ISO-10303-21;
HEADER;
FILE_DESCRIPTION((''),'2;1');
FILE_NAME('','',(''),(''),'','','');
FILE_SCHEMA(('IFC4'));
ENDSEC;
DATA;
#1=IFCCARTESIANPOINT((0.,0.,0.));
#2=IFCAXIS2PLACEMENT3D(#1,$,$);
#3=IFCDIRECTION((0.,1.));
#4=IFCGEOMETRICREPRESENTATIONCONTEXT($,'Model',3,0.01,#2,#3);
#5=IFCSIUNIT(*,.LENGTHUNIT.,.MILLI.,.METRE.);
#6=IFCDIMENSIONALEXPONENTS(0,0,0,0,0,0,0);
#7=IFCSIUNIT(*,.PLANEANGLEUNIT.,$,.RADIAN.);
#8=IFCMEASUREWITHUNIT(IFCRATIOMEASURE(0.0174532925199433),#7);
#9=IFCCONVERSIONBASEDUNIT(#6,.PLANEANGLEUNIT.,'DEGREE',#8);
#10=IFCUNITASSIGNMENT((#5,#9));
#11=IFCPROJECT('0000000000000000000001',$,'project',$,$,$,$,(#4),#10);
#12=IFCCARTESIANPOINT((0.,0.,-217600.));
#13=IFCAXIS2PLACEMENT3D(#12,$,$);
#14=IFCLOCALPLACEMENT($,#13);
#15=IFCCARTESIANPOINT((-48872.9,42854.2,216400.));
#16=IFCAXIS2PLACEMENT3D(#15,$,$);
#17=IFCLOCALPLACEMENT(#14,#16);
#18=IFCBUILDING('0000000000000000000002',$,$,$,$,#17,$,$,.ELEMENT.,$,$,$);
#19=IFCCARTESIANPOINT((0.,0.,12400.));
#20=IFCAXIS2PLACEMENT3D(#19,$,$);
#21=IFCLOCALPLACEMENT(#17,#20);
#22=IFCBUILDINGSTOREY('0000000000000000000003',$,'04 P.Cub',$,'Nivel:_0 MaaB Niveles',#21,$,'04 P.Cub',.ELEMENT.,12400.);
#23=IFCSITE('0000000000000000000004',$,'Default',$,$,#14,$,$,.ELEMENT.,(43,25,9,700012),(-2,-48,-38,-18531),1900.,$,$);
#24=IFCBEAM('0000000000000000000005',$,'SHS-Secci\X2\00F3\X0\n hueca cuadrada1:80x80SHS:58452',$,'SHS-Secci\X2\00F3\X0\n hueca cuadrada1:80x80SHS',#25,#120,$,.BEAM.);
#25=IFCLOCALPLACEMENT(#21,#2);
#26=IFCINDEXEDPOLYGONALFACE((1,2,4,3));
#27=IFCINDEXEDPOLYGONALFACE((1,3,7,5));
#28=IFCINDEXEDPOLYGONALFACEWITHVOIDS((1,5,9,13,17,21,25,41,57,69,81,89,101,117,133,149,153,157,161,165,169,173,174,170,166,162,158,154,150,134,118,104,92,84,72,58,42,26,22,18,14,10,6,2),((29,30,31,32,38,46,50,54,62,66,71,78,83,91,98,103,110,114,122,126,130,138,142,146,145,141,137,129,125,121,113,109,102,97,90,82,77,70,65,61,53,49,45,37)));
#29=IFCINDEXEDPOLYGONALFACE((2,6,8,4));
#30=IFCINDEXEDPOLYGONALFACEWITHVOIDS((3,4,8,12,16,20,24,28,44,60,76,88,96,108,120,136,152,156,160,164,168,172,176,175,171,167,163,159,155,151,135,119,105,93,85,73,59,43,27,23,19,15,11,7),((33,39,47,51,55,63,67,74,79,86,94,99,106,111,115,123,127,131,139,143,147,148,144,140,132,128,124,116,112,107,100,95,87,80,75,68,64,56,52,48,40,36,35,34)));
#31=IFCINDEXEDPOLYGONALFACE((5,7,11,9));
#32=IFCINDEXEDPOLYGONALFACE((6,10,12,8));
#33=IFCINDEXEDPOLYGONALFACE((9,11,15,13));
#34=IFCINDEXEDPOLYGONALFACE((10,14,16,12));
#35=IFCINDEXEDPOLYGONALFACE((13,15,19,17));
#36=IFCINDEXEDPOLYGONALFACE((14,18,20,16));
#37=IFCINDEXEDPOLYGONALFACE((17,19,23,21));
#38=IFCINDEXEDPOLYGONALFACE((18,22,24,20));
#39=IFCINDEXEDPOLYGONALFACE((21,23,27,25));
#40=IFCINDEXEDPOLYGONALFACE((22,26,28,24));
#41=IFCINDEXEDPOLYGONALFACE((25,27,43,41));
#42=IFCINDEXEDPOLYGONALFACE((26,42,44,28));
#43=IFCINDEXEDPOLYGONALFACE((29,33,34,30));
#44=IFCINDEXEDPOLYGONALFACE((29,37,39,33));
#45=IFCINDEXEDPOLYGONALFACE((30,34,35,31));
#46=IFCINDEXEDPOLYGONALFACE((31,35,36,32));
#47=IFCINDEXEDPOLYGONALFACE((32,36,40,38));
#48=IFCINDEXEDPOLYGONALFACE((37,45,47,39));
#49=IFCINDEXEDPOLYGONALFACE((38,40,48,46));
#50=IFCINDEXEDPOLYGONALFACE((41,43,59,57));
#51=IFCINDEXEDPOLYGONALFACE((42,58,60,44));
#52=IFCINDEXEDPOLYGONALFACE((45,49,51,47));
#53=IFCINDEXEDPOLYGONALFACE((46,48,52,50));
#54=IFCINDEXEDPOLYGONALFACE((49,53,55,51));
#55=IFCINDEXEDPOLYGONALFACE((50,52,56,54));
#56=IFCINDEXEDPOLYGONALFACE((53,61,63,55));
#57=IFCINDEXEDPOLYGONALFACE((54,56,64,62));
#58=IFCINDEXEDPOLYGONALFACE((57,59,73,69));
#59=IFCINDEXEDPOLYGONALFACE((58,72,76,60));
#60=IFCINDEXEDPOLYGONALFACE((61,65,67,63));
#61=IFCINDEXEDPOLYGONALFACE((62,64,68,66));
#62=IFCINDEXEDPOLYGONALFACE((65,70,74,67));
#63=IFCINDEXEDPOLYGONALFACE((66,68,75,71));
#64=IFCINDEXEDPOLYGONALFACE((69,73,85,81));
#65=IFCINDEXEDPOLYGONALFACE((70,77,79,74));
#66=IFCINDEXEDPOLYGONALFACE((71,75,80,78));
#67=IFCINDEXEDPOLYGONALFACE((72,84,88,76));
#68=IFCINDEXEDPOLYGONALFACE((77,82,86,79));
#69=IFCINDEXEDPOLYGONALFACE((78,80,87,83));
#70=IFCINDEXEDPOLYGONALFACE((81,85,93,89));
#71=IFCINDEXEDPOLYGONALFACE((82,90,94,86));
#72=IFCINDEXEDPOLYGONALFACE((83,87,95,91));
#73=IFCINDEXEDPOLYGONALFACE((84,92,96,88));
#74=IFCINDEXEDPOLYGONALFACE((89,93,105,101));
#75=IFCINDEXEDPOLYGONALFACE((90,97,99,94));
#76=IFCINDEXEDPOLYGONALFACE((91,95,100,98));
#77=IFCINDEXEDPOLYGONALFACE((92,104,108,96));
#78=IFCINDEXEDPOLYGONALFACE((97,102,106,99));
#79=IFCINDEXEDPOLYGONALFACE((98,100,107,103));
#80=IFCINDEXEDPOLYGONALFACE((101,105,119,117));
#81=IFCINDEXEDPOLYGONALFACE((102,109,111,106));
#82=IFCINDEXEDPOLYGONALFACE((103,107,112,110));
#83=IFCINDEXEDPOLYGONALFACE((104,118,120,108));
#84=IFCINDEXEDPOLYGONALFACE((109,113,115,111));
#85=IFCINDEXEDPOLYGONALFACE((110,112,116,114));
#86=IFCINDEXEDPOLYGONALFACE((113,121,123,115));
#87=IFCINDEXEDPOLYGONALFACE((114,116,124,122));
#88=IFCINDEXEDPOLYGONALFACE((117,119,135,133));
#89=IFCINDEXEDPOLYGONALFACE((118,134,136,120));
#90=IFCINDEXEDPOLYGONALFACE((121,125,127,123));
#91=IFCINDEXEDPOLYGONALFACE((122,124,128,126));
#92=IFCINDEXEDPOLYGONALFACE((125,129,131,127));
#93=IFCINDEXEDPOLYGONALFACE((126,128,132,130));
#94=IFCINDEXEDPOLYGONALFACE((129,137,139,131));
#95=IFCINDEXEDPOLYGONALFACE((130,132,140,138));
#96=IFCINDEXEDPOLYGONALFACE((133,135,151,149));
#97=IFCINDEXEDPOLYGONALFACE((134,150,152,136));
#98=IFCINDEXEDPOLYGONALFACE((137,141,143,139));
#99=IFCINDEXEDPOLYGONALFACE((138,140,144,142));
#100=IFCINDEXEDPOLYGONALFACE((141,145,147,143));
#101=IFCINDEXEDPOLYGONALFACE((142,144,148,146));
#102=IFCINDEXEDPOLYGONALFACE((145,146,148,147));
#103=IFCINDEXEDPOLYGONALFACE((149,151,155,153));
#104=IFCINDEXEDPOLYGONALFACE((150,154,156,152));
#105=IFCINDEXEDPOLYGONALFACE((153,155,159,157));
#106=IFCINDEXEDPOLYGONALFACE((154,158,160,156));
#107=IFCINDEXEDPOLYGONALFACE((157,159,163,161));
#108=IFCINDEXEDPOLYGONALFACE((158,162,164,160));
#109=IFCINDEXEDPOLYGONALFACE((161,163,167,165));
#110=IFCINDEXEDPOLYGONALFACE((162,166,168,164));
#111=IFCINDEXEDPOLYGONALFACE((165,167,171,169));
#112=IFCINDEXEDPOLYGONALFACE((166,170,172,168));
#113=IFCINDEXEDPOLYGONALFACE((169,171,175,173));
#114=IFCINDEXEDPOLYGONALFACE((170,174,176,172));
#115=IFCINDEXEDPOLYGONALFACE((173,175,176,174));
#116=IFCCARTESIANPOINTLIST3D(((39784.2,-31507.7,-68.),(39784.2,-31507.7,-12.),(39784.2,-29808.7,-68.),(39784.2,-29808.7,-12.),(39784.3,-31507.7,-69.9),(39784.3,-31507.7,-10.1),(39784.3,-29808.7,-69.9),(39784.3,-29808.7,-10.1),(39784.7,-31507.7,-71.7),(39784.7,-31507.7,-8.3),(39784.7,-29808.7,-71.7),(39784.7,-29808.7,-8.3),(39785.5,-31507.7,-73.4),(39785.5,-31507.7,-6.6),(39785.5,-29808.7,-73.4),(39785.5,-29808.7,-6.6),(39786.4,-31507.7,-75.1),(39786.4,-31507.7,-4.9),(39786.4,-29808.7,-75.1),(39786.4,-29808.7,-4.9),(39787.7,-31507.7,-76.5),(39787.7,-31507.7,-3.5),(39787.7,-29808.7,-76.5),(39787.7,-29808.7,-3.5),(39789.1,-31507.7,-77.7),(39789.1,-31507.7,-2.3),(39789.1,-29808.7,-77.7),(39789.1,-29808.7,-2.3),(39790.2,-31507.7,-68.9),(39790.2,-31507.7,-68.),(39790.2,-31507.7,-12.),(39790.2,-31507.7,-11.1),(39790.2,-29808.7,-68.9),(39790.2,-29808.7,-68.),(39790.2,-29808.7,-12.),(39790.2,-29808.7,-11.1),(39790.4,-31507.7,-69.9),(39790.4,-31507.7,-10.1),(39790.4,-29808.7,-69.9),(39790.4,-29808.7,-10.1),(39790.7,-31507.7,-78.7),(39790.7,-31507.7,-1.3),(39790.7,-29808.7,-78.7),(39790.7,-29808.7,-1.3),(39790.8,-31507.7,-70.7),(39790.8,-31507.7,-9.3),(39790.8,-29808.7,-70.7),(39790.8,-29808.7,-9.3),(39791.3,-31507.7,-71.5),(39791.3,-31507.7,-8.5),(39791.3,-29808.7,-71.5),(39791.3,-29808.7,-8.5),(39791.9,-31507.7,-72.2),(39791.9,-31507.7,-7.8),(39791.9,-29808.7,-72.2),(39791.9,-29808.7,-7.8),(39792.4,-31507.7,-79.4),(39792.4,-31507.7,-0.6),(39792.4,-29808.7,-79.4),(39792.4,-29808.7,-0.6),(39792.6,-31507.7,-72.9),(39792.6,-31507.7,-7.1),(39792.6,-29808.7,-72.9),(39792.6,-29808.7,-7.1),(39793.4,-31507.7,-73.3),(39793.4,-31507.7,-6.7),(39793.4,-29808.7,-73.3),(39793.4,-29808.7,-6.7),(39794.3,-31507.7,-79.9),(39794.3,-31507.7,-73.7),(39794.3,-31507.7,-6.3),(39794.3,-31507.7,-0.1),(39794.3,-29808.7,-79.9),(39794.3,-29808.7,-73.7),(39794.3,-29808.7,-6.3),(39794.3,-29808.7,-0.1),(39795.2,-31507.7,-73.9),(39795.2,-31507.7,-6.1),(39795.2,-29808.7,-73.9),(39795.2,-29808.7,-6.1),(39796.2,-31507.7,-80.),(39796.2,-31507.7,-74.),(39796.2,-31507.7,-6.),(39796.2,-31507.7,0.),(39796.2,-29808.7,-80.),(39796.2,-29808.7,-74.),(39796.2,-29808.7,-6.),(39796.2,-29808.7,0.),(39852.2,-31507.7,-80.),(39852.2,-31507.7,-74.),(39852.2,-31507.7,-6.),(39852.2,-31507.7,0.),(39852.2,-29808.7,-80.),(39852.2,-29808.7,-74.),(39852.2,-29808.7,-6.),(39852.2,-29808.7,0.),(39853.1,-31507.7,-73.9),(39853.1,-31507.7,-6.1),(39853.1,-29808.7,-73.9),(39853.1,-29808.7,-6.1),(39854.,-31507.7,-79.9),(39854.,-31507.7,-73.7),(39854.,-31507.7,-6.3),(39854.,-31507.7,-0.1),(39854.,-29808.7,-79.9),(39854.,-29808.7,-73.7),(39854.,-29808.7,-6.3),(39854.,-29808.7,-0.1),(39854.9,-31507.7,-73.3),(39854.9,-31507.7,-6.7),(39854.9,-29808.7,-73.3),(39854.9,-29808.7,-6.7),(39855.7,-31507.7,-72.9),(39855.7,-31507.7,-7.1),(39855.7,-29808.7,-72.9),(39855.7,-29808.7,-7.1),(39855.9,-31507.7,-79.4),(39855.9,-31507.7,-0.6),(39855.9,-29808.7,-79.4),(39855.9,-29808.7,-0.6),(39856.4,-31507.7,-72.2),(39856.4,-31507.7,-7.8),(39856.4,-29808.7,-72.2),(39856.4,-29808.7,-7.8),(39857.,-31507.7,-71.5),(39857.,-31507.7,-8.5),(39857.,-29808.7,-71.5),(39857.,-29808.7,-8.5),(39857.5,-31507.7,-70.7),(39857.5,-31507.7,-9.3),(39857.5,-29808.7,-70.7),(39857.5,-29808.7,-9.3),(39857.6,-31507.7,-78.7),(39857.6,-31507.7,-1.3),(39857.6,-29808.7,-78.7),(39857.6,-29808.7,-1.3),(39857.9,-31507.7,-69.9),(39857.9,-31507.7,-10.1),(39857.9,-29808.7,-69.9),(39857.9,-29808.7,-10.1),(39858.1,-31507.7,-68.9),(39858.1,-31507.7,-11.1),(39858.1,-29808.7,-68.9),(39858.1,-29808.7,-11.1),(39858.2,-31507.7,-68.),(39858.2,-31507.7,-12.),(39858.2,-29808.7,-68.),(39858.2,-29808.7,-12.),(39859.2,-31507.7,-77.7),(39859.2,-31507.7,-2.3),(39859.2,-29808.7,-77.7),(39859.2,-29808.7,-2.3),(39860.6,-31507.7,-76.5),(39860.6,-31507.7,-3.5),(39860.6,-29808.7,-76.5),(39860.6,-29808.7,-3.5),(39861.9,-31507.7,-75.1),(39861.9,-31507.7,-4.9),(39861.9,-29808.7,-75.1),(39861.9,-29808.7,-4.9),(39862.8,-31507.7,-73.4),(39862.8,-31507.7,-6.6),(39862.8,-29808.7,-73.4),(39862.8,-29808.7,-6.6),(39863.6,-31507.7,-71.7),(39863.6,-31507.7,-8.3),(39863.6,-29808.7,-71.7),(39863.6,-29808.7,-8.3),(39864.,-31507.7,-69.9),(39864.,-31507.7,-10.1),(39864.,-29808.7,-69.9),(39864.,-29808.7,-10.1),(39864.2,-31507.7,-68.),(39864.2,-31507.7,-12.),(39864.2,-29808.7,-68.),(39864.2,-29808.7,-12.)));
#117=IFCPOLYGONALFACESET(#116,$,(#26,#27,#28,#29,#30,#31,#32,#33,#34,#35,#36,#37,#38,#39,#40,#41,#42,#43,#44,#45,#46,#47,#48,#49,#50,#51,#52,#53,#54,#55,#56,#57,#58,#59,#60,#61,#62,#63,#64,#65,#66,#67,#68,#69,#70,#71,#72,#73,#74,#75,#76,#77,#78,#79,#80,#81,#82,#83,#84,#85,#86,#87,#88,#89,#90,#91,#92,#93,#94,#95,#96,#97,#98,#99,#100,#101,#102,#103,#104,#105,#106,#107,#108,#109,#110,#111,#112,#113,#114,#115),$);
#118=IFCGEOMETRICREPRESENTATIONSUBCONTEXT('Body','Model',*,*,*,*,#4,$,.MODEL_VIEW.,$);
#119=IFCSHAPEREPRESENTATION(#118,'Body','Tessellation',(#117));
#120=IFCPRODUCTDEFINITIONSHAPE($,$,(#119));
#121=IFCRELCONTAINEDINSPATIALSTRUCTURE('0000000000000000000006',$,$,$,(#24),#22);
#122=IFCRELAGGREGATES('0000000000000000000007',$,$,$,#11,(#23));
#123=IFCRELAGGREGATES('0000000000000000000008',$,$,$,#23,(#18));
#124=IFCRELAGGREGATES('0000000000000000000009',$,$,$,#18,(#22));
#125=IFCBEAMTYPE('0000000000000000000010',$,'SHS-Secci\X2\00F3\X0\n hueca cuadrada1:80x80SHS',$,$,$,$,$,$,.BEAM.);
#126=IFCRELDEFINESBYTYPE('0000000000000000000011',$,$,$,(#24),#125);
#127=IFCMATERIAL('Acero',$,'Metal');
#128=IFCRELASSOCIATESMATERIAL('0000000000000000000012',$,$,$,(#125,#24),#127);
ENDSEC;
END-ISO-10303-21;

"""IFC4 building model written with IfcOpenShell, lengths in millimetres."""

from ifc_helpers import new_model, entity, si_unit, converted_unit, direction, frame, origin, place, context, subcontext, project, spatial, indexed_curve, outline, extrude, source, transform, mapped, material, type_object, type_shapes, element, save


model = new_model("IFC4")

# Units and contexts
model_context = context("Model", 3, precision=0.01, world=origin(), true_north=direction((0.0, 1.0)))
body_context = subcontext(model_context, "Body", "Model", "MODEL_VIEW")
ifc_project = project(units=[si_unit("LENGTHUNIT", "METRE", prefix="MILLI"), converted_unit("PLANEANGLEUNIT", "DEGREE", entity("IfcRatioMeasure", 0.0174532925199433), si_unit("PLANEANGLEUNIT", "RADIAN"), dimensions=[0, 0, 0, 0, 0, 0, 0])], contexts=[model_context])

# Site, building, storey
site_placement = place(None, frame((0.0, 0.0, -217600.0)))
site = spatial("IfcSite", under=ifc_project, at=site_placement, Name="Default", CompositionType="ELEMENT", RefLatitude=(43, 25, 9, 700012), RefLongitude=(-2, -48, -38, -18531), RefElevation=1900.0)
building_placement = place(site_placement, frame((-48872.9, 42854.2, 216400.0)))
building = spatial("IfcBuilding", under=site, at=building_placement, CompositionType="ELEMENT")
storey_placement = place(building_placement, frame((0.0, 0.0, 12400.0)))
storey = spatial("IfcBuildingStorey", under=building, at=storey_placement, Name="04 P.Cub", ObjectType="Nivel:_0 MaaB Niveles", LongName="04 P.Cub", CompositionType="ELEMENT", Elevation=12400.0)

# Shared definitions
ifc_material_1 = material(Name="Acero", Category="Metal")

# Beam
beam_type_1 = type_object("IfcBeamType", Name="SHS-Sección hueca cuadrada1:80x80SHS", PredefinedType="BEAM", material=ifc_material_1)
shared_shape_1 = source(origin(), body_context, "Body", "SweptSolid", [
    extrude(outline(indexed_curve([(-40.0, -28.0), (-39.9, -29.9), (-39.4, -31.7), (-38.7, -33.4), (-37.7, -35.1), (-36.5, -36.5), (-35.1, -37.7), (-33.4, -38.7), (-31.7, -39.4), (-29.9, -39.9), (-28.0, -40.0), (28.0, -40.0), (29.9, -39.9), (31.7, -39.4), (33.4, -38.7), (35.1, -37.7), (36.5, -36.5), (37.7, -35.1), (38.7, -33.4), (39.4, -31.7), (39.9, -29.9), (40.0, -28.0), (40.0, 28.0), (39.9, 29.9), (39.4, 31.7), (38.7, 33.4), (37.7, 35.1), (36.5, 36.5), (35.1, 37.7), (33.4, 38.7), (31.7, 39.4), (29.9, 39.9), (28.0, 40.0), (-28.0, 40.0), (-29.9, 39.9), (-31.7, 39.4), (-33.4, 38.7), (-35.1, 37.7), (-36.5, 36.5), (-37.7, 35.1), (-38.7, 33.4), (-39.4, 31.7), (-39.9, 29.9), (-40.0, 28.0), (-40.0, -28.0)], self_intersect=False), holes=[indexed_curve([(28.0, -34.0), (-28.0, -34.0), (-28.9, -33.9), (-29.9, -33.7), (-30.7, -33.3), (-31.5, -32.9), (-32.2, -32.2), (-32.9, -31.5), (-33.3, -30.7), (-33.7, -29.9), (-33.9, -28.9), (-34.0, -28.0), (-34.0, 28.0), (-33.9, 28.9), (-33.7, 29.9), (-33.3, 30.7), (-32.9, 31.5), (-32.2, 32.2), (-31.5, 32.9), (-30.7, 33.3), (-29.9, 33.7), (-28.9, 33.9), (-28.0, 34.0), (28.0, 34.0), (28.9, 33.9), (29.9, 33.7), (30.7, 33.3), (31.5, 32.9), (32.2, 32.2), (32.9, 31.5), (33.3, 30.7), (33.7, 29.9), (33.9, 28.9), (34.0, 28.0), (34.0, -28.0), (33.9, -28.9), (33.7, -29.9), (33.3, -30.7), (32.9, -31.5), (32.2, -32.2), (31.5, -32.9), (30.7, -33.3), (29.9, -33.7), (28.9, -33.9), (28.0, -34.0)], self_intersect=False)]), frame((-827.5, 0.0, 0.0), z_axis=(1.0, 0.0, 0.0), x_axis=(0.0, -1.0, 0.0)), (0.0, 0.0, 1.0), 1699.0),
])
type_shapes(beam_type_1, [shared_shape_1])
beam_1_placement = place(storey_placement, frame((39824.2, -30636.2, -40.0), z_axis=(0.0, 0.0, 1.0), x_axis=(0.0, -1.0, 0.0)))
element("IfcBeam", 1, at=beam_1_placement, inside=storey, type_object=beam_type_1, material=ifc_material_1, Name="SHS-Sección hueca cuadrada1:80x80SHS:58452", ObjectType="SHS-Sección hueca cuadrada1:80x80SHS", PredefinedType="BEAM", context=body_context, shape_type="MappedRepresentation", body=[
    mapped(shared_shape_1, transform((0.0, 0.0, 0.0), scale=1.0)),
])

save(model, "model.ifc")
